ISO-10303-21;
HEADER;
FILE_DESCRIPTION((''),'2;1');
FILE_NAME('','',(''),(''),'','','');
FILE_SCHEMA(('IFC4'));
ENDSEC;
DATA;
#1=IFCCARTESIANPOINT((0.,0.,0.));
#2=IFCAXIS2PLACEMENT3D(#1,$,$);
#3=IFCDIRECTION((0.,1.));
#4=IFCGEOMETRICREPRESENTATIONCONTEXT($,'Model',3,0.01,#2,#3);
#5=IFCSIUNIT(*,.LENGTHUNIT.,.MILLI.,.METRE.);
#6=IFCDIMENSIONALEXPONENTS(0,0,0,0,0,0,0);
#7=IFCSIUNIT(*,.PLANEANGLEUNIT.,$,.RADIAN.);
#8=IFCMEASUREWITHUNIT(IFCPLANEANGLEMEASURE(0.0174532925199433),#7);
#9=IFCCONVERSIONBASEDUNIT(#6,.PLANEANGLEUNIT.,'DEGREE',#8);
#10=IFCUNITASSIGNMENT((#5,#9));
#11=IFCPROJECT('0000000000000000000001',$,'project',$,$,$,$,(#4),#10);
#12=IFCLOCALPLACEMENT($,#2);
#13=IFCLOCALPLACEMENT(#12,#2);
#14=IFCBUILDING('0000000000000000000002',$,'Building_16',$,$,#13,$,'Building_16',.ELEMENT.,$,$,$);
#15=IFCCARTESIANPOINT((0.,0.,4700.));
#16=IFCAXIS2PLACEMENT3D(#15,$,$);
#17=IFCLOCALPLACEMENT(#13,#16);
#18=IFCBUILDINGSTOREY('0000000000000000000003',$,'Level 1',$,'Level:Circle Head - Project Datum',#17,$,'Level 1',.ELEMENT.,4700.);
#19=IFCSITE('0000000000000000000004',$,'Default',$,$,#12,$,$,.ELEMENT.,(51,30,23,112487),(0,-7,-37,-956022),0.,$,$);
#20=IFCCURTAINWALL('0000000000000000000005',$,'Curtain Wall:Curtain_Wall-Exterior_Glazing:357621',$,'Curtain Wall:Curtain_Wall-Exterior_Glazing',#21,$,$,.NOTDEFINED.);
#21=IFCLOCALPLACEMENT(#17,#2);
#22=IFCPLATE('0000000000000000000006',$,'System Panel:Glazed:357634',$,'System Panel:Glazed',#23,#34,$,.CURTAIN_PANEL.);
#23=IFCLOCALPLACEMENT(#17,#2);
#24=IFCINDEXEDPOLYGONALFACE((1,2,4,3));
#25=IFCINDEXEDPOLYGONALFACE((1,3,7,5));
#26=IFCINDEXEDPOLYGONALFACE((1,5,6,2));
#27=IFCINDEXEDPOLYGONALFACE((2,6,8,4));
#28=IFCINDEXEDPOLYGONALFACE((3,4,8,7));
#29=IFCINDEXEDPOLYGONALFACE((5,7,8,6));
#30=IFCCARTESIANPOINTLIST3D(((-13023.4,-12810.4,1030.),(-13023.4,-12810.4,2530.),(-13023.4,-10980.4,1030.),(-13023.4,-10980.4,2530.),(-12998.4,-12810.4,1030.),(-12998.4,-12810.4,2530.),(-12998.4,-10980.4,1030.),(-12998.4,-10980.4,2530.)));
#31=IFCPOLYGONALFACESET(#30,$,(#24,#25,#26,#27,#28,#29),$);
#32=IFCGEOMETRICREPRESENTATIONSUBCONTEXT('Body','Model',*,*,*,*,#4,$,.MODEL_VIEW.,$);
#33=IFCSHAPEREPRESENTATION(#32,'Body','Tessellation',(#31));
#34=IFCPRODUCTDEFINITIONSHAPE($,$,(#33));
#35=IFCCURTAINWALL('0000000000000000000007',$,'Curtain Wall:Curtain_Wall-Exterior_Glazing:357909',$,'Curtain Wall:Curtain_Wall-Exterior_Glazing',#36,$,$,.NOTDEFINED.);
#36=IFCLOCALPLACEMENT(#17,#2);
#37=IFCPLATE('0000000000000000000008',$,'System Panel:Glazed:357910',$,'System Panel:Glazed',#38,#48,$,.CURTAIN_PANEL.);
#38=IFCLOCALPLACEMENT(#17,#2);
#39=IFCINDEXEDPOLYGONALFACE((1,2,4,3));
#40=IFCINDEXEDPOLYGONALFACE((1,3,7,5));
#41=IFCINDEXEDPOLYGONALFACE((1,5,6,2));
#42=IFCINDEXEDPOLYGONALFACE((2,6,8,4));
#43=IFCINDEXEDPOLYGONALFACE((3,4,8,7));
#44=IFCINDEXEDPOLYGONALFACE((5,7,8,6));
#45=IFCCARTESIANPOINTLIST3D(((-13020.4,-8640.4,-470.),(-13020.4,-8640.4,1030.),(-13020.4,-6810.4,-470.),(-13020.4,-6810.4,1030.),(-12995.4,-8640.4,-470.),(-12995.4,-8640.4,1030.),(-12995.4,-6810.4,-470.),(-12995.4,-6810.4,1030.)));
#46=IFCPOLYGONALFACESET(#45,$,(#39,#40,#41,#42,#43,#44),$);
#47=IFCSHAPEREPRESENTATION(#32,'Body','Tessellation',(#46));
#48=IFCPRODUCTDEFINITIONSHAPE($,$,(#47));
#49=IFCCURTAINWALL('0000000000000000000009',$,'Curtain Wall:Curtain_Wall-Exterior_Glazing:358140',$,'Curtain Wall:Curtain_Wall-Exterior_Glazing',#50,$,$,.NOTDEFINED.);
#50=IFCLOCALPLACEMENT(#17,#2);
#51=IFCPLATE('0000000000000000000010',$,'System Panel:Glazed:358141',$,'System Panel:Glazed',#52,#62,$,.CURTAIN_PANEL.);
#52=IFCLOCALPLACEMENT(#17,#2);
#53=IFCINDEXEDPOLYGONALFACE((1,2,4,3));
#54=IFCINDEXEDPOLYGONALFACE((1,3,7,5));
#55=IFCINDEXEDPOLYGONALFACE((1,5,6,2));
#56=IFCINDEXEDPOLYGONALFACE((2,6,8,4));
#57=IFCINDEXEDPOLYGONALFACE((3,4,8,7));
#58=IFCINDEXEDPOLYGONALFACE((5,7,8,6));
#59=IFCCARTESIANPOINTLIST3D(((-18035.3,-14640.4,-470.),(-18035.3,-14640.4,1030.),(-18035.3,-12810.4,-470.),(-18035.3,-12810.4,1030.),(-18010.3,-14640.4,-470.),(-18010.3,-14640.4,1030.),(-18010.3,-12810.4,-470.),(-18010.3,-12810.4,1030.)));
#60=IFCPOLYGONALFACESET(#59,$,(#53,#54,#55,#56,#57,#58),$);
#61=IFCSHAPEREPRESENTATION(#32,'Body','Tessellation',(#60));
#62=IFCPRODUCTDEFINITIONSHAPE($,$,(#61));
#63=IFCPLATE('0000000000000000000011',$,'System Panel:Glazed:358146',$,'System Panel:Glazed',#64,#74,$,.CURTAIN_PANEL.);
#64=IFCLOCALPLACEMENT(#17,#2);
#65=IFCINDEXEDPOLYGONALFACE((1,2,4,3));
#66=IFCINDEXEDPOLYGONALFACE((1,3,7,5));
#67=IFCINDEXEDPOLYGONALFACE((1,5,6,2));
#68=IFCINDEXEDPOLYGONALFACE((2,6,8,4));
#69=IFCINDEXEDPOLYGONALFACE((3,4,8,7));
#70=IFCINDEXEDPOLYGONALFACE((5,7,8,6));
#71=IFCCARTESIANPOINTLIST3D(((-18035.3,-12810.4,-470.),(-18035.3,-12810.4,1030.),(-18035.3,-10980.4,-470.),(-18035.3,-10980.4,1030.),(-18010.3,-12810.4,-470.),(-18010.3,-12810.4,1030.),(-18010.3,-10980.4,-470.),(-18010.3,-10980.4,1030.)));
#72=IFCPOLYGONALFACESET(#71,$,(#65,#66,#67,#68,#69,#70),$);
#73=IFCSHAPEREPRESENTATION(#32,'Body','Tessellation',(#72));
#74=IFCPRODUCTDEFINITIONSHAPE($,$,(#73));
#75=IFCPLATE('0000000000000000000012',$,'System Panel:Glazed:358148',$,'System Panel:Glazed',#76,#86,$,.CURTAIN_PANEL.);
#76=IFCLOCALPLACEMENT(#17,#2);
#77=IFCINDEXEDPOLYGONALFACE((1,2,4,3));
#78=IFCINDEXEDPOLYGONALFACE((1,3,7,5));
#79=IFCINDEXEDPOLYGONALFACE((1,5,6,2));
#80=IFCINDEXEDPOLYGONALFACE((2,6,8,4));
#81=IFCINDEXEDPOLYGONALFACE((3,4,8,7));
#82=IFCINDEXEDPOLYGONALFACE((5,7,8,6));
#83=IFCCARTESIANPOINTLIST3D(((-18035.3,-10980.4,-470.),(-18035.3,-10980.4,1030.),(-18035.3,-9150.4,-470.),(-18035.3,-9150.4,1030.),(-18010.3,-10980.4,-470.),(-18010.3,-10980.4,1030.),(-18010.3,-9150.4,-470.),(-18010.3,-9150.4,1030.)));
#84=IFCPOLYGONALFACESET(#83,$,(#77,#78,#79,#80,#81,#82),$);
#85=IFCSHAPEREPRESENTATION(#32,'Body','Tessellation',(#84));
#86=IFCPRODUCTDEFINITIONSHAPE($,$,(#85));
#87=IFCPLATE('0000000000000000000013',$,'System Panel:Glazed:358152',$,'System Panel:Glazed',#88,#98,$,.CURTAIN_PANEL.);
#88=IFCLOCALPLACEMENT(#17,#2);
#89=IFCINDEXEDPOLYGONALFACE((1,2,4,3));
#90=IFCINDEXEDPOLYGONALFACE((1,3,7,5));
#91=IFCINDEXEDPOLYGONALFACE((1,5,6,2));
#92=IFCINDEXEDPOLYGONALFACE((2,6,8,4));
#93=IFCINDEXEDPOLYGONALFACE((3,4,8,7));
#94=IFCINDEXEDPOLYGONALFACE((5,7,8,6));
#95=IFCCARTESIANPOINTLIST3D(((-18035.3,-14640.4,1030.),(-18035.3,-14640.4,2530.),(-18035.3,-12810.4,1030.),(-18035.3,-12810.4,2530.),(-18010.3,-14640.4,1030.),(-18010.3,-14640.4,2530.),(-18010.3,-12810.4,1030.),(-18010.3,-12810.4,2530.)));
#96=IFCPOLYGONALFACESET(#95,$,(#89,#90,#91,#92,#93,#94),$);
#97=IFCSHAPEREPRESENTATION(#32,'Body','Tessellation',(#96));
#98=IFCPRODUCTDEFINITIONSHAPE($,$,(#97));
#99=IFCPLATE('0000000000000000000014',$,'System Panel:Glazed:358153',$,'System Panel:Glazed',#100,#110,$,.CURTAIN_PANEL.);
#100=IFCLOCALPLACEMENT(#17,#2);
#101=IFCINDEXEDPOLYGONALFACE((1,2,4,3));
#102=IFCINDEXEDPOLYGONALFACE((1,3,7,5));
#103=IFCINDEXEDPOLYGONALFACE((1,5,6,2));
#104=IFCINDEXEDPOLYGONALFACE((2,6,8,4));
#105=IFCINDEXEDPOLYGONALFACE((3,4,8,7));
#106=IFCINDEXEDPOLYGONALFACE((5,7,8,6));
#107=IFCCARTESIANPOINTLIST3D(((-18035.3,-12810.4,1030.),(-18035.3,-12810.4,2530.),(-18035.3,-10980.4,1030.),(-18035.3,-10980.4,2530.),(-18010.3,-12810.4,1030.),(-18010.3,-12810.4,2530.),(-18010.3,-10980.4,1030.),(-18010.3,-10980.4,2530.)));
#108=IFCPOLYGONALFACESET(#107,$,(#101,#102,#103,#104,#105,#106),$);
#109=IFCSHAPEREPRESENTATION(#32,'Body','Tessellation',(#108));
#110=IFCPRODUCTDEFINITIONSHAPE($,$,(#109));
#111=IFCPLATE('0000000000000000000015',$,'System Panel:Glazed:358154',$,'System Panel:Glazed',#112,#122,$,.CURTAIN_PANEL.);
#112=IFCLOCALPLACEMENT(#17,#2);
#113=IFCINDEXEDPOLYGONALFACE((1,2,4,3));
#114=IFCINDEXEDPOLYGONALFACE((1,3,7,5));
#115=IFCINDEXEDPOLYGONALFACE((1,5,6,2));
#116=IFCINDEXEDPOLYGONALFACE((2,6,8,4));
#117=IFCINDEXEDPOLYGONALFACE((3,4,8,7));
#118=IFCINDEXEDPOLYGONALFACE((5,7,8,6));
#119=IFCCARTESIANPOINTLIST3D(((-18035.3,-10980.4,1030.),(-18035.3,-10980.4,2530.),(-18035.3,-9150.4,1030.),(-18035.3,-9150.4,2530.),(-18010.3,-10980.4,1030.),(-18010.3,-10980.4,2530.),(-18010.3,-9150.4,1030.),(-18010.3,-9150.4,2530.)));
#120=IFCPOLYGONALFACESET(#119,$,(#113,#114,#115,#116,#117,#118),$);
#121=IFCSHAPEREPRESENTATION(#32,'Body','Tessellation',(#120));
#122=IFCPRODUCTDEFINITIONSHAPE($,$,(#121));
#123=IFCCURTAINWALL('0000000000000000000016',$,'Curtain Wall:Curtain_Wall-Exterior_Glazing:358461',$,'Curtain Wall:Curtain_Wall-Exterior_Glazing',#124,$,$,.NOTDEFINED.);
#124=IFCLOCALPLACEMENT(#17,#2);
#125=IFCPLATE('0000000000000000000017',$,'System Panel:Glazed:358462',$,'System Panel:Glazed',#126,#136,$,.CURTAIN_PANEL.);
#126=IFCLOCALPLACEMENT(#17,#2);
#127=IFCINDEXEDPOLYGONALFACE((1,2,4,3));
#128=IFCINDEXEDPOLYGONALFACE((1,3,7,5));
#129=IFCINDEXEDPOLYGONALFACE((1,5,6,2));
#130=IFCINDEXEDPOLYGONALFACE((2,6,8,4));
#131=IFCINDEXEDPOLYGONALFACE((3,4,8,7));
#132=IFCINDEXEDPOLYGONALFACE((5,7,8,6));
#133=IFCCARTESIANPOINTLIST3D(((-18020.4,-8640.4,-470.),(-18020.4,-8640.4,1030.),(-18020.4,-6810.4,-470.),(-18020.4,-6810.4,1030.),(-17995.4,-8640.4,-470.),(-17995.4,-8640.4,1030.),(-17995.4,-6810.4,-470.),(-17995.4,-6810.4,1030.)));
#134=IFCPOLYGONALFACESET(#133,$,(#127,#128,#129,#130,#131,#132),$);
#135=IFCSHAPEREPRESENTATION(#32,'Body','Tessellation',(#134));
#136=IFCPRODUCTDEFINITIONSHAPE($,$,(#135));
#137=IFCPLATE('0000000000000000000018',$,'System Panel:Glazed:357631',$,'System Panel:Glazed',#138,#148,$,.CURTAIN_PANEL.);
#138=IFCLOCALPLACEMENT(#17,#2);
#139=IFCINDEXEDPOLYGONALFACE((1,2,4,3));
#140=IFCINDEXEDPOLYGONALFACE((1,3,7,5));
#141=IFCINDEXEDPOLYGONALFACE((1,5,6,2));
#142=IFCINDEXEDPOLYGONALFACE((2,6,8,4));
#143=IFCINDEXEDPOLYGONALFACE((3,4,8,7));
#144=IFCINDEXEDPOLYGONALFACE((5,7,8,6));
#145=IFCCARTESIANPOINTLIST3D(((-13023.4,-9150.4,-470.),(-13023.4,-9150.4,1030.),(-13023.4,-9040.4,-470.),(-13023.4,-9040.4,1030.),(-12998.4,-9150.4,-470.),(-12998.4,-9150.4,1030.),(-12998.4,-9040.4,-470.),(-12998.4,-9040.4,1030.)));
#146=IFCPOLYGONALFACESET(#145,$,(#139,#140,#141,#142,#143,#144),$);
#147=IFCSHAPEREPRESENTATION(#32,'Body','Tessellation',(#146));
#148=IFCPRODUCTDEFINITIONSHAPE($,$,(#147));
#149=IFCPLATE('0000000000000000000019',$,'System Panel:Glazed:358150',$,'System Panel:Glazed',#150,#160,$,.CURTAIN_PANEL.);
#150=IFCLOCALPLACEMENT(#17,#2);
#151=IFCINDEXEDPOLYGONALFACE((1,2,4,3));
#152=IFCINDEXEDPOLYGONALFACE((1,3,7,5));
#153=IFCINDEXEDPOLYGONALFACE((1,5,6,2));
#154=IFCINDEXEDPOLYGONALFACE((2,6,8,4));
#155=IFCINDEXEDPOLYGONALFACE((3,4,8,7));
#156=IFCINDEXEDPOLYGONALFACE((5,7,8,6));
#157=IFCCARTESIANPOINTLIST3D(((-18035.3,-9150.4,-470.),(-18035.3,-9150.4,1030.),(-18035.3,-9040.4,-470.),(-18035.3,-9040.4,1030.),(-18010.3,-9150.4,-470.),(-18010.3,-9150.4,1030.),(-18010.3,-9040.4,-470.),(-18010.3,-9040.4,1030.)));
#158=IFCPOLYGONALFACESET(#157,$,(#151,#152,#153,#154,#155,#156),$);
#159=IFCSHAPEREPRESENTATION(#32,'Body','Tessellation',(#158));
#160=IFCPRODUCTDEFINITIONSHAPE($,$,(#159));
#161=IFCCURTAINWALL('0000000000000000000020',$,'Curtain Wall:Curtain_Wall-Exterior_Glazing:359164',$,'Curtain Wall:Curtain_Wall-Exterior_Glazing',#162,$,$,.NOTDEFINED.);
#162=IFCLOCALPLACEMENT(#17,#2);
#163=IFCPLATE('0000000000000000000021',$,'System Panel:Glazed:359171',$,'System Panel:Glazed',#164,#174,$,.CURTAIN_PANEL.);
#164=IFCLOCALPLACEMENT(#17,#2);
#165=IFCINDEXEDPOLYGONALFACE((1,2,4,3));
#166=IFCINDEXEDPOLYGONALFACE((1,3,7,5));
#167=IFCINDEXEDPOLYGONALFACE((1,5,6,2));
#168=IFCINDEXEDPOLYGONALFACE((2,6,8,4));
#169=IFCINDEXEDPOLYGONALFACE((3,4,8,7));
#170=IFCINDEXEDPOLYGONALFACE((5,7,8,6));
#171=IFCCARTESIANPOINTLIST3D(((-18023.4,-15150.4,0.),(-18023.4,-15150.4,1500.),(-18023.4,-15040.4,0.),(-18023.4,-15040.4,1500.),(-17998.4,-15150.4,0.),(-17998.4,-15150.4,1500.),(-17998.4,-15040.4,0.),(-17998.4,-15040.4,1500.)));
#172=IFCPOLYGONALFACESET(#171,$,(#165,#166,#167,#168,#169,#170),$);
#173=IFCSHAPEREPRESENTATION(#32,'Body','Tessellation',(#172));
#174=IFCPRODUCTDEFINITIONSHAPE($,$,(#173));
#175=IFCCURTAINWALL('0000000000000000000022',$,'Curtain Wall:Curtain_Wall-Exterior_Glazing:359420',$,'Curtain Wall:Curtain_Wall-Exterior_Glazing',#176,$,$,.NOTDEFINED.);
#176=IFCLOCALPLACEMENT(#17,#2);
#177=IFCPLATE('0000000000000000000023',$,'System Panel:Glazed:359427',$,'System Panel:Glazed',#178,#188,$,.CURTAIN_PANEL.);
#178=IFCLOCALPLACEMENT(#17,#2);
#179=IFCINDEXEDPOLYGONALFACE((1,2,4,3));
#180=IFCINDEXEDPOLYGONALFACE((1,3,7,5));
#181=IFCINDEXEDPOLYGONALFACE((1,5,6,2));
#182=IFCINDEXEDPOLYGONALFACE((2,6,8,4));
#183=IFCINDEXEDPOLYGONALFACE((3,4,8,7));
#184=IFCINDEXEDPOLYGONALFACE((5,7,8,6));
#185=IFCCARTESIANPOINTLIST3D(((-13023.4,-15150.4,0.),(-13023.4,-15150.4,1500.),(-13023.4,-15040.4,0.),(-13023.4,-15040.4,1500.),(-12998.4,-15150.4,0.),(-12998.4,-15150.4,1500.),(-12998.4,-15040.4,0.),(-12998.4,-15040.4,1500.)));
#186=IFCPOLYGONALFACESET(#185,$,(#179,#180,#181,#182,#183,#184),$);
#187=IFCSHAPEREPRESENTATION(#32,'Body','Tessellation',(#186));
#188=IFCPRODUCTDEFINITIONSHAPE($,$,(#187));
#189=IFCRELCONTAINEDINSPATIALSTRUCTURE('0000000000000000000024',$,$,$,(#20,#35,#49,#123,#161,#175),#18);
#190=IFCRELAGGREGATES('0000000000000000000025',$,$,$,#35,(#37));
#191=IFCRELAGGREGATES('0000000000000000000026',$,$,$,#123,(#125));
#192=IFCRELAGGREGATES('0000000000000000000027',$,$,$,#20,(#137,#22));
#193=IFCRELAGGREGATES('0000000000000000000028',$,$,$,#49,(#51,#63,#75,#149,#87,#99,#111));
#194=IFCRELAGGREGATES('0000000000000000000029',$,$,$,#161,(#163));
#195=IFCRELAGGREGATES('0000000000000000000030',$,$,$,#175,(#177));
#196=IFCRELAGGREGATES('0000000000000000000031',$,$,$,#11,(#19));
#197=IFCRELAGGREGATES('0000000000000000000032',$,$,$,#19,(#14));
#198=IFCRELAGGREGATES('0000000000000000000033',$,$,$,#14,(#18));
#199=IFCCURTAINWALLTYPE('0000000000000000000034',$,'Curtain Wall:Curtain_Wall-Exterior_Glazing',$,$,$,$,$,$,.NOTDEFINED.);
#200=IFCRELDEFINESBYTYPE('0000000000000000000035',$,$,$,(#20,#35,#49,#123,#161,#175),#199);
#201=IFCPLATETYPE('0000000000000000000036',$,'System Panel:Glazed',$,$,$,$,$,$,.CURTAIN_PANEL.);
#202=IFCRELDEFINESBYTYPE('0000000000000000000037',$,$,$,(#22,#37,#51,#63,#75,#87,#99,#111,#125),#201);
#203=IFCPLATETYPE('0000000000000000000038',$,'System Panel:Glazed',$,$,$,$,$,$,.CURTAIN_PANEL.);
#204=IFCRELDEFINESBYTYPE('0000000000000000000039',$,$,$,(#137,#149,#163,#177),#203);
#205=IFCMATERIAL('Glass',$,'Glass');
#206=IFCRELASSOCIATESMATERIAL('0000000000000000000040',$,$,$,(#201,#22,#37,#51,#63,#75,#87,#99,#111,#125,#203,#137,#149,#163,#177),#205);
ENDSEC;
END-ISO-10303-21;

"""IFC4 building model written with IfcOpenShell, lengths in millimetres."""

from ifc_helpers import new_model, entity, si_unit, converted_unit, direction, frame, origin, place, context, subcontext, project, spatial, indexed_curve, outline, extrude, source, transform, mapped, material, type_object, type_shapes, element, aggregate, save


model = new_model("IFC4")

# Units and contexts
model_context = context("Model", 3, precision=0.01, world=origin(), true_north=direction((0.0, 1.0)))
body_context = subcontext(model_context, "Body", "Model", "MODEL_VIEW")
ifc_project = project(units=[si_unit("LENGTHUNIT", "METRE", prefix="MILLI"), converted_unit("PLANEANGLEUNIT", "DEGREE", entity("IfcPlaneAngleMeasure", 0.0174532925199433), si_unit("PLANEANGLEUNIT", "RADIAN"), dimensions=[0, 0, 0, 0, 0, 0, 0])], contexts=[model_context])

# Site, building, storey
site_placement = place(None, origin())
site = spatial("IfcSite", under=ifc_project, at=site_placement, Name="Default", CompositionType="ELEMENT", RefLatitude=(51, 30, 23, 112487), RefLongitude=(0, -7, -37, -956022), RefElevation=0.0)
building_placement = place(site_placement, origin())
building = spatial("IfcBuilding", under=site, at=building_placement, Name="Building_16", LongName="Building_16", CompositionType="ELEMENT")
storey_placement = place(building_placement, frame((0.0, 0.0, 4700.0)))
storey = spatial("IfcBuildingStorey", under=building, at=storey_placement, Name="Level 1", ObjectType="Level:Circle Head - Project Datum", LongName="Level 1", CompositionType="ELEMENT", Elevation=4700.0)

# Curtain wall, plate
curtain_wall_type = type_object("IfcCurtainWallType", Name="Curtain Wall:Curtain_Wall-Exterior_Glazing", PredefinedType="NOTDEFINED")
curtain_wall_1_placement = place(storey_placement, frame((0.0, 0.0, -4700.0)))
curtain_wall_1 = element("IfcCurtainWall", 1, at=curtain_wall_1_placement, inside=storey, type_object=curtain_wall_type, Name="Curtain Wall:Curtain_Wall-Exterior_Glazing:357621", ObjectType="Curtain Wall:Curtain_Wall-Exterior_Glazing", PredefinedType="NOTDEFINED")
ifc_material_1 = material(Name="Glass", Category="Glass")
plate_type_1 = type_object("IfcPlateType", Name="System Panel:Glazed", PredefinedType="CURTAIN_PANEL", material=ifc_material_1)
shared_shape_1 = source(origin(), body_context, "Body", "SweptSolid", [
    extrude(outline(indexed_curve([(-12.5, -915.0), (12.5, -915.0), (12.5, 915.0), (-12.5, 915.0), (-12.5, -915.0)], self_intersect=False)), frame((0.0, 37.0, 0.0), z_axis=(0.0, 0.0, 1.0), x_axis=(0.0, 1.0, 0.0)), (0.0, 0.0, 1.0), 1500.0),
])
type_shapes(plate_type_1, [shared_shape_1])
plate_1_placement = place(curtain_wall_1_placement, frame((-12973.9, -11895.4, 5730.0), z_axis=(0.0, 0.0, 1.0), x_axis=(0.0, 1.0, 0.0)))
plate_1 = element("IfcPlate", 2, at=plate_1_placement, type_object=plate_type_1, material=ifc_material_1, Name="System Panel:Glazed:357634", ObjectType="System Panel:Glazed", PredefinedType="CURTAIN_PANEL", context=body_context, shape_type="MappedRepresentation", body=[
    mapped(shared_shape_1, transform((0.0, 0.0, 0.0), scale=1.0)),
])

# Curtain wall, plate
curtain_wall_2_placement = place(storey_placement, frame((0.0, 0.0, -4700.0)))
curtain_wall_2 = element("IfcCurtainWall", 3, at=curtain_wall_2_placement, inside=storey, type_object=curtain_wall_type, Name="Curtain Wall:Curtain_Wall-Exterior_Glazing:357909", ObjectType="Curtain Wall:Curtain_Wall-Exterior_Glazing", PredefinedType="NOTDEFINED")
plate_2_placement = place(curtain_wall_2_placement, frame((-12970.9, -7725.4, 4230.0), z_axis=(0.0, 0.0, 1.0), x_axis=(0.0, 1.0, 0.0)))
plate_2 = element("IfcPlate", 4, at=plate_2_placement, type_object=plate_type_1, material=ifc_material_1, Name="System Panel:Glazed:357910", ObjectType="System Panel:Glazed", PredefinedType="CURTAIN_PANEL", context=body_context, shape_type="MappedRepresentation", body=[
    mapped(shared_shape_1, transform((0.0, 0.0, 0.0), scale=1.0)),
])
aggregate(curtain_wall_2, [plate_2])

# Curtain wall, plates
curtain_wall_3_placement = place(storey_placement, frame((0.0, 0.0, -4700.0)))
curtain_wall_3 = element("IfcCurtainWall", 5, at=curtain_wall_3_placement, inside=storey, type_object=curtain_wall_type, Name="Curtain Wall:Curtain_Wall-Exterior_Glazing:358140", ObjectType="Curtain Wall:Curtain_Wall-Exterior_Glazing", PredefinedType="NOTDEFINED")
plate_3_placement = place(curtain_wall_3_placement, frame((-17985.8, -13725.4, 4230.0), z_axis=(0.0, 0.0, 1.0), x_axis=(0.0, 1.0, 0.0)))
plate_3 = element("IfcPlate", 6, at=plate_3_placement, type_object=plate_type_1, material=ifc_material_1, Name="System Panel:Glazed:358141", ObjectType="System Panel:Glazed", PredefinedType="CURTAIN_PANEL", context=body_context, shape_type="MappedRepresentation", body=[
    mapped(shared_shape_1, transform((0.0, 0.0, 0.0), scale=1.0)),
])
plate_4_placement = place(curtain_wall_3_placement, frame((-17985.8, -11895.4, 4230.0), z_axis=(0.0, 0.0, 1.0), x_axis=(0.0, 1.0, 0.0)))
plate_4 = element("IfcPlate", 7, at=plate_4_placement, type_object=plate_type_1, material=ifc_material_1, Name="System Panel:Glazed:358146", ObjectType="System Panel:Glazed", PredefinedType="CURTAIN_PANEL", context=body_context, shape_type="MappedRepresentation", body=[
    mapped(shared_shape_1, transform((0.0, 0.0, 0.0), scale=1.0)),
])
plate_5_placement = place(curtain_wall_3_placement, frame((-17985.8, -10065.4, 4230.0), z_axis=(0.0, 0.0, 1.0), x_axis=(0.0, 1.0, 0.0)))
plate_5 = element("IfcPlate", 8, at=plate_5_placement, type_object=plate_type_1, material=ifc_material_1, Name="System Panel:Glazed:358148", ObjectType="System Panel:Glazed", PredefinedType="CURTAIN_PANEL", context=body_context, shape_type="MappedRepresentation", body=[
    mapped(shared_shape_1, transform((0.0, 0.0, 0.0), scale=1.0)),
])
plate_6_placement = place(curtain_wall_3_placement, frame((-17985.8, -13725.4, 5730.0), z_axis=(0.0, 0.0, 1.0), x_axis=(0.0, 1.0, 0.0)))
plate_6 = element("IfcPlate", 9, at=plate_6_placement, type_object=plate_type_1, material=ifc_material_1, Name="System Panel:Glazed:358152", ObjectType="System Panel:Glazed", PredefinedType="CURTAIN_PANEL", context=body_context, shape_type="MappedRepresentation", body=[
    mapped(shared_shape_1, transform((0.0, 0.0, 0.0), scale=1.0)),
])
plate_7_placement = place(curtain_wall_3_placement, frame((-17985.8, -11895.4, 5730.0), z_axis=(0.0, 0.0, 1.0), x_axis=(0.0, 1.0, 0.0)))
plate_7 = element("IfcPlate", 10, at=plate_7_placement, type_object=plate_type_1, material=ifc_material_1, Name="System Panel:Glazed:358153", ObjectType="System Panel:Glazed", PredefinedType="CURTAIN_PANEL", context=body_context, shape_type="MappedRepresentation", body=[
    mapped(shared_shape_1, transform((0.0, 0.0, 0.0), scale=1.0)),
])
plate_8_placement = place(curtain_wall_3_placement, frame((-17985.8, -10065.4, 5730.0), z_axis=(0.0, 0.0, 1.0), x_axis=(0.0, 1.0, 0.0)))
plate_8 = element("IfcPlate", 11, at=plate_8_placement, type_object=plate_type_1, material=ifc_material_1, Name="System Panel:Glazed:358154", ObjectType="System Panel:Glazed", PredefinedType="CURTAIN_PANEL", context=body_context, shape_type="MappedRepresentation", body=[
    mapped(shared_shape_1, transform((0.0, 0.0, 0.0), scale=1.0)),
])

# Curtain wall, plate
curtain_wall_4_placement = place(storey_placement, frame((0.0, 0.0, -4700.0)))
curtain_wall_4 = element("IfcCurtainWall", 12, at=curtain_wall_4_placement, inside=storey, type_object=curtain_wall_type, Name="Curtain Wall:Curtain_Wall-Exterior_Glazing:358461", ObjectType="Curtain Wall:Curtain_Wall-Exterior_Glazing", PredefinedType="NOTDEFINED")
plate_9_placement = place(curtain_wall_4_placement, frame((-17970.9, -7725.4, 4230.0), z_axis=(0.0, 0.0, 1.0), x_axis=(0.0, 1.0, 0.0)))
plate_9 = element("IfcPlate", 13, at=plate_9_placement, type_object=plate_type_1, material=ifc_material_1, Name="System Panel:Glazed:358462", ObjectType="System Panel:Glazed", PredefinedType="CURTAIN_PANEL", context=body_context, shape_type="MappedRepresentation", body=[
    mapped(shared_shape_1, transform((0.0, 0.0, 0.0), scale=1.0)),
])
aggregate(curtain_wall_4, [plate_9])

# Plates
plate_type_2 = type_object("IfcPlateType", Name="System Panel:Glazed", PredefinedType="CURTAIN_PANEL", material=ifc_material_1)
shared_shape_2 = source(origin(), body_context, "Body", "SweptSolid", [
    extrude(outline(indexed_curve([(-12.5, -55.0), (12.5, -55.0), (12.5, 55.0), (-12.5, 55.0), (-12.5, -55.0)], self_intersect=False)), frame((0.0, 37.0, 0.0), z_axis=(0.0, 0.0, 1.0), x_axis=(0.0, 1.0, 0.0)), (0.0, 0.0, 1.0), 1500.0),
])
type_shapes(plate_type_2, [shared_shape_2])
plate_10_placement = place(curtain_wall_1_placement, frame((-12973.9, -9095.4, 4230.0), z_axis=(0.0, 0.0, 1.0), x_axis=(0.0, 1.0, 0.0)))
plate_10 = element("IfcPlate", 14, at=plate_10_placement, type_object=plate_type_2, material=ifc_material_1, Name="System Panel:Glazed:357631", ObjectType="System Panel:Glazed", PredefinedType="CURTAIN_PANEL", context=body_context, shape_type="MappedRepresentation", body=[
    mapped(shared_shape_2, transform((0.0, 0.0, 0.0), scale=1.0)),
])
aggregate(curtain_wall_1, [plate_10, plate_1])
plate_11_placement = place(curtain_wall_3_placement, frame((-17985.8, -9095.4, 4230.0), z_axis=(0.0, 0.0, 1.0), x_axis=(0.0, 1.0, 0.0)))
plate_11 = element("IfcPlate", 15, at=plate_11_placement, type_object=plate_type_2, material=ifc_material_1, Name="System Panel:Glazed:358150", ObjectType="System Panel:Glazed", PredefinedType="CURTAIN_PANEL", context=body_context, shape_type="MappedRepresentation", body=[
    mapped(shared_shape_2, transform((0.0, 0.0, 0.0), scale=1.0)),
])
aggregate(curtain_wall_3, [plate_3, plate_4, plate_5, plate_11, plate_6, plate_7, plate_8])

# Curtain walls, plates
curtain_wall_5_placement = place(storey_placement, frame((0.0, 0.0, -4700.0)))
curtain_wall_5 = element("IfcCurtainWall", 16, at=curtain_wall_5_placement, inside=storey, type_object=curtain_wall_type, Name="Curtain Wall:Curtain_Wall-Exterior_Glazing:359164", ObjectType="Curtain Wall:Curtain_Wall-Exterior_Glazing", PredefinedType="NOTDEFINED")
plate_12_placement = place(curtain_wall_5_placement, frame((-17973.9, -15095.4, 4700.0), z_axis=(0.0, 0.0, 1.0), x_axis=(0.0, 1.0, 0.0)))
plate_12 = element("IfcPlate", 17, at=plate_12_placement, type_object=plate_type_2, material=ifc_material_1, Name="System Panel:Glazed:359171", ObjectType="System Panel:Glazed", PredefinedType="CURTAIN_PANEL", context=body_context, shape_type="MappedRepresentation", body=[
    mapped(shared_shape_2, transform((0.0, 0.0, 0.0), scale=1.0)),
])
aggregate(curtain_wall_5, [plate_12])
curtain_wall_6_placement = place(storey_placement, frame((0.0, 0.0, -4700.0)))
curtain_wall_6 = element("IfcCurtainWall", 18, at=curtain_wall_6_placement, inside=storey, type_object=curtain_wall_type, Name="Curtain Wall:Curtain_Wall-Exterior_Glazing:359420", ObjectType="Curtain Wall:Curtain_Wall-Exterior_Glazing", PredefinedType="NOTDEFINED")
plate_13_placement = place(curtain_wall_6_placement, frame((-12973.9, -15095.4, 4700.0), z_axis=(0.0, 0.0, 1.0), x_axis=(0.0, 1.0, 0.0)))
plate_13 = element("IfcPlate", 19, at=plate_13_placement, type_object=plate_type_2, material=ifc_material_1, Name="System Panel:Glazed:359427", ObjectType="System Panel:Glazed", PredefinedType="CURTAIN_PANEL", context=body_context, shape_type="MappedRepresentation", body=[
    mapped(shared_shape_2, transform((0.0, 0.0, 0.0), scale=1.0)),
])
aggregate(curtain_wall_6, [plate_13])

save(model, "model.ifc")
